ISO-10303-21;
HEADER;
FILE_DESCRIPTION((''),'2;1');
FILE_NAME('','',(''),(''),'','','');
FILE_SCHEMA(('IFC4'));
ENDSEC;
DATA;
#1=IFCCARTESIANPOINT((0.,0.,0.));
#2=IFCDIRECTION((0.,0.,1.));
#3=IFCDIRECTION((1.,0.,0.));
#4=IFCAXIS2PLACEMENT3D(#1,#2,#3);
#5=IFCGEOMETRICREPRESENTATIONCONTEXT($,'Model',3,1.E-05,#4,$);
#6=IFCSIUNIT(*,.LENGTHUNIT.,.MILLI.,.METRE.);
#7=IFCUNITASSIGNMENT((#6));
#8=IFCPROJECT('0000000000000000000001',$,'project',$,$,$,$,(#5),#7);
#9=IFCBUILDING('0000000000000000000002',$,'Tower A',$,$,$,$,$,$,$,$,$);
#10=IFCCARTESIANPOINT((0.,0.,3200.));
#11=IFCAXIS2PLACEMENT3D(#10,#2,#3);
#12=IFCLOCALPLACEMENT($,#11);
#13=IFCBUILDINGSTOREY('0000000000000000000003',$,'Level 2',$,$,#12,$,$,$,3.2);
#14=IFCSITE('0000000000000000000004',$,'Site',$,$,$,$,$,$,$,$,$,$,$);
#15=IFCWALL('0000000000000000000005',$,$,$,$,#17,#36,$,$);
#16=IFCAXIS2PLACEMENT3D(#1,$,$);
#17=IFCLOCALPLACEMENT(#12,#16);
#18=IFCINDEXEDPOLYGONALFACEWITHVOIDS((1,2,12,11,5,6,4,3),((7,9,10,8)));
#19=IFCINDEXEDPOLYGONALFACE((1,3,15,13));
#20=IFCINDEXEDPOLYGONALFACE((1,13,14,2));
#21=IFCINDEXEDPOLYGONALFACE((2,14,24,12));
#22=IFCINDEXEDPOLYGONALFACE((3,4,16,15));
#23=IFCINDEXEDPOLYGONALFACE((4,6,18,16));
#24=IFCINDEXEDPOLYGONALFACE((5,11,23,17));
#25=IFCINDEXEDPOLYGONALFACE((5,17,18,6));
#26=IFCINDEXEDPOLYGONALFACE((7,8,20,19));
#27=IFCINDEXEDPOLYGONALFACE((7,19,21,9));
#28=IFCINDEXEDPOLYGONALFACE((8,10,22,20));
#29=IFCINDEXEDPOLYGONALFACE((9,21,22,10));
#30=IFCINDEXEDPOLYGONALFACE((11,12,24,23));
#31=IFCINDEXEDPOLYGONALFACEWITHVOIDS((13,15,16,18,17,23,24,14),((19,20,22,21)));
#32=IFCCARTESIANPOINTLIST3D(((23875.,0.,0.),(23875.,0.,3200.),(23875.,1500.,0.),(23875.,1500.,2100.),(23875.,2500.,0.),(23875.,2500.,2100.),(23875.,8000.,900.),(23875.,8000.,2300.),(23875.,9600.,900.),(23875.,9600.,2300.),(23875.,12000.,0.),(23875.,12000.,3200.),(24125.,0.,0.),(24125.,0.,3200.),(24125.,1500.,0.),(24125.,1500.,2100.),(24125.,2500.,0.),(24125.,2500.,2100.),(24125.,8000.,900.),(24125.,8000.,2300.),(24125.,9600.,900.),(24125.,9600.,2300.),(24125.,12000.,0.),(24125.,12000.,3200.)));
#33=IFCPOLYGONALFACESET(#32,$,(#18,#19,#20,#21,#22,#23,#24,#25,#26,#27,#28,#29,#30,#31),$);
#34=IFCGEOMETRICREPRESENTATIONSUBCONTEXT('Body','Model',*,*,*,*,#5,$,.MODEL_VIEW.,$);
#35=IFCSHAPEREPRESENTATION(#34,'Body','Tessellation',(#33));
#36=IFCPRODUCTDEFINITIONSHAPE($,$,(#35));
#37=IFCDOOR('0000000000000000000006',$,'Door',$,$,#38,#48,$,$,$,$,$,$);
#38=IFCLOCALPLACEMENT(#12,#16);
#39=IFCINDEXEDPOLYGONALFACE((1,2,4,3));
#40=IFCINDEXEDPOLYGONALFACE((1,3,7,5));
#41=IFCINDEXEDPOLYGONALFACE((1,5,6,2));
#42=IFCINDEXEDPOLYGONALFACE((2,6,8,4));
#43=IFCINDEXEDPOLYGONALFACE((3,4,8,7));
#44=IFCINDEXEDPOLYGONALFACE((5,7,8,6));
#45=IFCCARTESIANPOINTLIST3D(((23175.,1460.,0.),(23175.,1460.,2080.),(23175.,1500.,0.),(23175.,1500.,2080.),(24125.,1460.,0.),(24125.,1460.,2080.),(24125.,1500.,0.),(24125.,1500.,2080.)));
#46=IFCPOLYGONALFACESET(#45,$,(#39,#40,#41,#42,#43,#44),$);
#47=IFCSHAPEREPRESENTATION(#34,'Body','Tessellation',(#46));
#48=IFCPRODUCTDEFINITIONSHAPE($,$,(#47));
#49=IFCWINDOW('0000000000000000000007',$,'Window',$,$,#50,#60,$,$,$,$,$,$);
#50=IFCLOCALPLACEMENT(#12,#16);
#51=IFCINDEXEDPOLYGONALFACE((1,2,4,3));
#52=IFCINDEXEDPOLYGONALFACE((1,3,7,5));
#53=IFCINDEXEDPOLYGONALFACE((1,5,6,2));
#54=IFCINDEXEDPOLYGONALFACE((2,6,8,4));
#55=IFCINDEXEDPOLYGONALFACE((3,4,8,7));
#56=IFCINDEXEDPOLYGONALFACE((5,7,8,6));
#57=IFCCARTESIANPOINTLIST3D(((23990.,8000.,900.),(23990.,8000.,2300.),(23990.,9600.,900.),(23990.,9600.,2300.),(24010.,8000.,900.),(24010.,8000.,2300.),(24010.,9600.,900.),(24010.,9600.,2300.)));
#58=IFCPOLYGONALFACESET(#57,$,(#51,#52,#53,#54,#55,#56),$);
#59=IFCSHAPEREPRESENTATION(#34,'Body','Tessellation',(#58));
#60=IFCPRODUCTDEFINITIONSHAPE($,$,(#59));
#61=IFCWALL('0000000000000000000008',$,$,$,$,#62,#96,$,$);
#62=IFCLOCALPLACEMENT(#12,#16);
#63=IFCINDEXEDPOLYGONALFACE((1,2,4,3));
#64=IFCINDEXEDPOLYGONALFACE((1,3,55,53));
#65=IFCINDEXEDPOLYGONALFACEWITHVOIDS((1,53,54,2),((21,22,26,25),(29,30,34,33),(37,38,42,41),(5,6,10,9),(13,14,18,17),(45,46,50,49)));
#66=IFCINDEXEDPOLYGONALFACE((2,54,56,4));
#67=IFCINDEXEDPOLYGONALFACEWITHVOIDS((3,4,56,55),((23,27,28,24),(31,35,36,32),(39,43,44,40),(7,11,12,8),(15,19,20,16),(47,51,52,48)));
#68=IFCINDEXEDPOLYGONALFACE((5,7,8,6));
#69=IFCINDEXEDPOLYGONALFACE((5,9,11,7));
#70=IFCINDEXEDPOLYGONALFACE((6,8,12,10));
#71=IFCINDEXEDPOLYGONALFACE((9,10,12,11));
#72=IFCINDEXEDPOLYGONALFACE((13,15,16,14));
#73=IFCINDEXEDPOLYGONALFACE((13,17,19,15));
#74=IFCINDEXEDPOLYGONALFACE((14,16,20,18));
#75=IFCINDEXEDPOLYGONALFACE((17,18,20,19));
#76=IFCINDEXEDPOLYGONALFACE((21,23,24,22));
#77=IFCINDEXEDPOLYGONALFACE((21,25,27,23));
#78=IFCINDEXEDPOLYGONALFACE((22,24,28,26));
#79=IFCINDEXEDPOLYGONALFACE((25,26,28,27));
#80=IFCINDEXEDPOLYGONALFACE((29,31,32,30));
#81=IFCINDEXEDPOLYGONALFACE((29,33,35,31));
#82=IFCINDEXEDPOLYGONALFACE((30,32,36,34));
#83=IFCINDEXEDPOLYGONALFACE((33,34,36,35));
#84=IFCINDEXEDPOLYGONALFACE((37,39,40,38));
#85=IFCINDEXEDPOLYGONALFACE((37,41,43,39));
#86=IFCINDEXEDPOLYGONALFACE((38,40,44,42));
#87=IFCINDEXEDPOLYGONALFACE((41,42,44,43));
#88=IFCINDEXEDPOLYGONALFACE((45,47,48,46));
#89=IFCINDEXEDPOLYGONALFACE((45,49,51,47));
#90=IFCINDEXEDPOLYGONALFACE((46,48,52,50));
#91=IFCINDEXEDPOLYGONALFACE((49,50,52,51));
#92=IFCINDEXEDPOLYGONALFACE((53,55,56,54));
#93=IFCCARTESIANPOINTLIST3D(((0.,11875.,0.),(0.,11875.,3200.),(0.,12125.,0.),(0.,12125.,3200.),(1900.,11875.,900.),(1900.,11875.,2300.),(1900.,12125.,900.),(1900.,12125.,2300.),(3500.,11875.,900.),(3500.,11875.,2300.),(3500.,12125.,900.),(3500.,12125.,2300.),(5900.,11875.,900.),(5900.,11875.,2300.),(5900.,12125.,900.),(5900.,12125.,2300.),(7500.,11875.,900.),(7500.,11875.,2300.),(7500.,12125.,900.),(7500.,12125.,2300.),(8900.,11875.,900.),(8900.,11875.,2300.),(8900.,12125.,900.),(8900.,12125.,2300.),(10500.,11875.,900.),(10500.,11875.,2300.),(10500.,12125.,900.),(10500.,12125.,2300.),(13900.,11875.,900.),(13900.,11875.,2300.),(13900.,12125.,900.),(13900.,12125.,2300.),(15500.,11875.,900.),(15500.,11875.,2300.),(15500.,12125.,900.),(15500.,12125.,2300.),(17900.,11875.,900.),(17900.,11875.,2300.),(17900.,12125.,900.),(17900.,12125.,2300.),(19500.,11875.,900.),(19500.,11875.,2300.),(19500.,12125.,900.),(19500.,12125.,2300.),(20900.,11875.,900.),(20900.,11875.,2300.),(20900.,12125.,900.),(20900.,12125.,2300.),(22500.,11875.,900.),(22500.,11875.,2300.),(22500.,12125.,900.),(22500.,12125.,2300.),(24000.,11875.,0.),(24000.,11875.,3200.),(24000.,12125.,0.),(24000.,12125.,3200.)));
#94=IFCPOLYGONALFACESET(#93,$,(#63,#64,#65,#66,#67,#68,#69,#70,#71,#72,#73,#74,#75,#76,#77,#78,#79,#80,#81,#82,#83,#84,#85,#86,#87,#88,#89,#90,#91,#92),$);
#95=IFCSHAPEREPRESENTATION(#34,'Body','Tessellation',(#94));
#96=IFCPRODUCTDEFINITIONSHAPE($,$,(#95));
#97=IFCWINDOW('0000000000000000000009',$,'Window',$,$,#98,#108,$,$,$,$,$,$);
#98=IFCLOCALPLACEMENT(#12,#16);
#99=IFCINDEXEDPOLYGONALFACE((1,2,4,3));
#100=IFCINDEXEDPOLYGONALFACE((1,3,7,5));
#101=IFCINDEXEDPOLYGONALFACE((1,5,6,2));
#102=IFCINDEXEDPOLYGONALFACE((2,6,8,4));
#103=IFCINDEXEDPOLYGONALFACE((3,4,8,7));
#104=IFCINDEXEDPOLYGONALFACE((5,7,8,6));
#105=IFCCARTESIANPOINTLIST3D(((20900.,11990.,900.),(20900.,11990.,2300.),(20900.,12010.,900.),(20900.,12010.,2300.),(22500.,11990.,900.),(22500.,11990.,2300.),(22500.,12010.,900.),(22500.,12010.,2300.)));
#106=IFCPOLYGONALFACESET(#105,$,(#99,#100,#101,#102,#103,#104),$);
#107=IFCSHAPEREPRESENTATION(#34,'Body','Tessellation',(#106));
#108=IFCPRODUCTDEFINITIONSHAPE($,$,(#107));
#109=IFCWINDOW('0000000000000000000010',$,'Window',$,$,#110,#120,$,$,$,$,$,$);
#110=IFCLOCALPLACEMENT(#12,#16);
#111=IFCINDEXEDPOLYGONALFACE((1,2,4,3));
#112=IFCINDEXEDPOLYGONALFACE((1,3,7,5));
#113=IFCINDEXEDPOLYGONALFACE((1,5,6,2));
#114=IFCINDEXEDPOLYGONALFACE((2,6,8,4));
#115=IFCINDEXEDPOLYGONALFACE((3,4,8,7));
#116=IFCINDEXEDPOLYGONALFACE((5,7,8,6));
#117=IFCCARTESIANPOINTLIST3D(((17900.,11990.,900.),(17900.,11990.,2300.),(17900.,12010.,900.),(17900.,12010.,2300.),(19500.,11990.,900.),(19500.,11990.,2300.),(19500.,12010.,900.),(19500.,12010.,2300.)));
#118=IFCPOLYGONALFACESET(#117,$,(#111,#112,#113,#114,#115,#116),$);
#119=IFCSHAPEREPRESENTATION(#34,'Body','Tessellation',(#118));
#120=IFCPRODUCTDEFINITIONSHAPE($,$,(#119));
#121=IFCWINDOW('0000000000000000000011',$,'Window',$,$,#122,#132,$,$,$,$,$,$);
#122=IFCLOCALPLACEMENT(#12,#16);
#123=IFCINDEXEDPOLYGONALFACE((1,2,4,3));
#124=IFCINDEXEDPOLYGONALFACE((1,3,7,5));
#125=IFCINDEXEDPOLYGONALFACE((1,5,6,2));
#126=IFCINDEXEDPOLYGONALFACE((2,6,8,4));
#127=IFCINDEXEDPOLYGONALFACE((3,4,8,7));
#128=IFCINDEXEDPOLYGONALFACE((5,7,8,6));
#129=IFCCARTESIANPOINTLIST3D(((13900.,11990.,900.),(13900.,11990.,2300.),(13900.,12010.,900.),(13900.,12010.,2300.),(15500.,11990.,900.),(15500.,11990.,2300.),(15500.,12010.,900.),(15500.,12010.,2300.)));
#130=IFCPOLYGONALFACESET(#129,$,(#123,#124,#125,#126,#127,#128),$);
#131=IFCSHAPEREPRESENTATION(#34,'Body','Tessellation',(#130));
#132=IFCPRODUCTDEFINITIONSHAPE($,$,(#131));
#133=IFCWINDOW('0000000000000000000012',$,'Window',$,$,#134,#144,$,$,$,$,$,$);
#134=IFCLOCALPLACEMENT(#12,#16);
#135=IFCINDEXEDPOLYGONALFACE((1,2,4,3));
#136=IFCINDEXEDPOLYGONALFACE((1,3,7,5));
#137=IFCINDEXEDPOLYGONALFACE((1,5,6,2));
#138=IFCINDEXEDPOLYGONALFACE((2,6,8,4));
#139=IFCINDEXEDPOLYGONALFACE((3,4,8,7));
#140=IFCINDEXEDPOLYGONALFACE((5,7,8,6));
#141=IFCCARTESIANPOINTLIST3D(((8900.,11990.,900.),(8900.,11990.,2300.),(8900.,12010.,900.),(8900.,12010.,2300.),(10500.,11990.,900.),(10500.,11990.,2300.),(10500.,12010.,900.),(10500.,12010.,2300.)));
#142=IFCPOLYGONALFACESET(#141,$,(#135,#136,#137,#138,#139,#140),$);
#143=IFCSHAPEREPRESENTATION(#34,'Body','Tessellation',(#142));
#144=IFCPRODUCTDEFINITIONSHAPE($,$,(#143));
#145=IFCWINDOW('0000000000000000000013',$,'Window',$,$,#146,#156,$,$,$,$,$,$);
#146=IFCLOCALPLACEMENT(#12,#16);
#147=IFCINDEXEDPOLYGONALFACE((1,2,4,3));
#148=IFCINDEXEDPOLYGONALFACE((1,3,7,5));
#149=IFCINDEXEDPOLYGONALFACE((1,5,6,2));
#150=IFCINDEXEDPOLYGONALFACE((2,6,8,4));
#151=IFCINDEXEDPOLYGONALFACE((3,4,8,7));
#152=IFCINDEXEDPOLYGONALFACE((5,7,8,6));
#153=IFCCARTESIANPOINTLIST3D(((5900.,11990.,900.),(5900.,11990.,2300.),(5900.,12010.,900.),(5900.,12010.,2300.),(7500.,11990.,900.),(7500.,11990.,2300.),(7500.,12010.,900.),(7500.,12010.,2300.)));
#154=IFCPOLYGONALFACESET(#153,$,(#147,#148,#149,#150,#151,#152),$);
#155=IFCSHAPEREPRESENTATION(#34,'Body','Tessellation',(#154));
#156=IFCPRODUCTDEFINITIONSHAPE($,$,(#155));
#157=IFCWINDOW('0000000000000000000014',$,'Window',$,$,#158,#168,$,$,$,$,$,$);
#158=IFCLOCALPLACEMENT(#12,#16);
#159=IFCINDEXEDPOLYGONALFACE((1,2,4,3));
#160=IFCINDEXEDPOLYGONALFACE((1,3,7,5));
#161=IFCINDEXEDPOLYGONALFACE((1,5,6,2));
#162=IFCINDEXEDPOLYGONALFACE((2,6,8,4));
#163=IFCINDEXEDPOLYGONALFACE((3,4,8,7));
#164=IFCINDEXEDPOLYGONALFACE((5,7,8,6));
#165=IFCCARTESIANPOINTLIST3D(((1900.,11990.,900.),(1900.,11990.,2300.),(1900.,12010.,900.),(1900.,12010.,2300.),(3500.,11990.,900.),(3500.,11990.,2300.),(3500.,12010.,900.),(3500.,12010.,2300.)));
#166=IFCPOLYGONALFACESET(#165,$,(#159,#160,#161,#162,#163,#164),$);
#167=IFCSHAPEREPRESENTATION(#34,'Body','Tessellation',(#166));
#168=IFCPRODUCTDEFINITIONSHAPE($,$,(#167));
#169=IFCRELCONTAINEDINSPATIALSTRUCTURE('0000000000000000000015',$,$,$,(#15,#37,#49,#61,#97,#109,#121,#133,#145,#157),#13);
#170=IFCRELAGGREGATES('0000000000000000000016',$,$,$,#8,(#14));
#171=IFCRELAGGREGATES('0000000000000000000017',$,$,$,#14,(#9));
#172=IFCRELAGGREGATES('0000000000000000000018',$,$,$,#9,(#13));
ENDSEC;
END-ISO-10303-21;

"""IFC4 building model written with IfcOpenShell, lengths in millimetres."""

from ifc_helpers import new_model, si_unit, frame, origin_with_axes, place, context, subcontext, project, spatial, indexed_curve, outline, extrude, element, fill, save


model = new_model("IFC4")

# Units and contexts
model_context = context("Model", 3, precision=1e-05, world=origin_with_axes())
body_context = subcontext(model_context, "Body", "Model", "MODEL_VIEW")
ifc_project = project(units=[si_unit("LENGTHUNIT", "METRE", prefix="MILLI")], contexts=[model_context])

# Site, building, storey
site = spatial("IfcSite", under=ifc_project, Name="Site")
building = spatial("IfcBuilding", under=site, Name="Tower A")
storey_placement = place(None, frame((0.0, 0.0, 3200.0), z_axis=(0.0, 0.0, 1.0), x_axis=(1.0, 0.0, 0.0)))
storey = spatial("IfcBuildingStorey", under=building, at=storey_placement, Name="Level 2", Elevation=3.2)

# Wall, openings, door, window
wall_1_placement = place(storey_placement, frame((24125.0, 0.0, 0.0), z_axis=(0.0, 0.0, 1.0), x_axis=(0.0, 1.0, 0.0)))
wall_1 = element("IfcWall", 1, at=wall_1_placement, inside=storey, context=body_context, shape_type="SweptSolid", body=[
    extrude(outline(indexed_curve([(0.0, 0.0), (0.0, 250.0), (12000.0, 250.0), (12000.0, 0.0), (0.0, 0.0)], self_intersect=False)), origin_with_axes(), (0.0, 0.0, 1.0), 3200.0),
])
opening_1_placement = place(wall_1_placement, frame((1500.0, 0.0, 0.0), z_axis=(0.0, 0.0, 1.0), x_axis=(1.0, 0.0, 0.0)))
opening_1 = element("IfcOpeningElement", 2, at=opening_1_placement, cuts=wall_1, context=body_context, shape_type="SweptSolid", body=[
    extrude(outline(indexed_curve([(0.0, 0.0), (0.0, 250.0), (1000.0, 250.0), (1000.0, 0.0), (0.0, 0.0)], self_intersect=False)), origin_with_axes(), (0.0, 0.0, 1.0), 2100.0),
])
opening_2_placement = place(wall_1_placement, frame((8000.0, 0.0, 900.0), z_axis=(0.0, 0.0, 1.0), x_axis=(1.0, 0.0, 0.0)))
opening_2 = element("IfcOpeningElement", 3, at=opening_2_placement, cuts=wall_1, context=body_context, shape_type="SweptSolid", body=[
    extrude(outline(indexed_curve([(0.0, 0.0), (0.0, 250.0), (1600.0, 250.0), (1600.0, 0.0), (0.0, 0.0)], self_intersect=False)), origin_with_axes(), (0.0, 0.0, 1.0), 1400.0),
])
door_1_placement = place(storey_placement, frame((24125.0, 1500.0, 0.0), z_axis=(0.0, 0.0, 1.0), x_axis=(-1.0, 0.0, 0.0)))
door_1 = element("IfcDoor", 4, at=door_1_placement, inside=storey, Name="Door", context=body_context, shape_type="SweptSolid", body=[
    extrude(outline(indexed_curve([(0.0, 0.0), (0.0, 40.0), (950.0, 40.0), (950.0, 0.0), (0.0, 0.0)], self_intersect=False)), origin_with_axes(), (0.0, 0.0, 1.0), 2080.0),
])
fill(opening_1, door_1)
window_1_placement = place(storey_placement, frame((24010.0, 8000.0, 900.0), z_axis=(0.0, 0.0, 1.0), x_axis=(0.0, 1.0, 0.0)))
window_1 = element("IfcWindow", 5, at=window_1_placement, inside=storey, Name="Window", context=body_context, shape_type="SweptSolid", body=[
    extrude(outline(indexed_curve([(0.0, 0.0), (0.0, 20.0), (1600.0, 20.0), (1600.0, 0.0), (0.0, 0.0)], self_intersect=False)), origin_with_axes(), (0.0, 0.0, 1.0), 1400.0),
])
fill(opening_2, window_1)

# Wall, openings, windows
wall_2_placement = place(storey_placement, frame((24000.0, 12125.0, 0.0), z_axis=(0.0, 0.0, 1.0), x_axis=(-1.0, 0.0, 0.0)))
wall_2 = element("IfcWall", 6, at=wall_2_placement, inside=storey, context=body_context, shape_type="SweptSolid", body=[
    extrude(outline(indexed_curve([(0.0, 0.0), (0.0, 250.0), (24000.0, 250.0), (24000.0, 0.0), (0.0, 0.0)], self_intersect=False)), origin_with_axes(), (0.0, 0.0, 1.0), 3200.0),
])
opening_3_placement = place(wall_2_placement, frame((1500.0, 0.0, 900.0), z_axis=(0.0, 0.0, 1.0), x_axis=(1.0, 0.0, 0.0)))
opening_3 = element("IfcOpeningElement", 7, at=opening_3_placement, cuts=wall_2, context=body_context, shape_type="SweptSolid", body=[
    extrude(outline(indexed_curve([(0.0, 0.0), (0.0, 250.0), (1600.0, 250.0), (1600.0, 0.0), (0.0, 0.0)], self_intersect=False)), origin_with_axes(), (0.0, 0.0, 1.0), 1400.0),
])
opening_4_placement = place(wall_2_placement, frame((4500.0, 0.0, 900.0), z_axis=(0.0, 0.0, 1.0), x_axis=(1.0, 0.0, 0.0)))
opening_4 = element("IfcOpeningElement", 8, at=opening_4_placement, cuts=wall_2, context=body_context, shape_type="SweptSolid", body=[
    extrude(outline(indexed_curve([(0.0, 0.0), (0.0, 250.0), (1600.0, 250.0), (1600.0, 0.0), (0.0, 0.0)], self_intersect=False)), origin_with_axes(), (0.0, 0.0, 1.0), 1400.0),
])
opening_5_placement = place(wall_2_placement, frame((8500.0, 0.0, 900.0), z_axis=(0.0, 0.0, 1.0), x_axis=(1.0, 0.0, 0.0)))
opening_5 = element("IfcOpeningElement", 9, at=opening_5_placement, cuts=wall_2, context=body_context, shape_type="SweptSolid", body=[
    extrude(outline(indexed_curve([(0.0, 0.0), (0.0, 250.0), (1600.0, 250.0), (1600.0, 0.0), (0.0, 0.0)], self_intersect=False)), origin_with_axes(), (0.0, 0.0, 1.0), 1400.0),
])
opening_6_placement = place(wall_2_placement, frame((13500.0, 0.0, 900.0), z_axis=(0.0, 0.0, 1.0), x_axis=(1.0, 0.0, 0.0)))
opening_6 = element("IfcOpeningElement", 10, at=opening_6_placement, cuts=wall_2, context=body_context, shape_type="SweptSolid", body=[
    extrude(outline(indexed_curve([(0.0, 0.0), (0.0, 250.0), (1600.0, 250.0), (1600.0, 0.0), (0.0, 0.0)], self_intersect=False)), origin_with_axes(), (0.0, 0.0, 1.0), 1400.0),
])
opening_7_placement = place(wall_2_placement, frame((16500.0, 0.0, 900.0), z_axis=(0.0, 0.0, 1.0), x_axis=(1.0, 0.0, 0.0)))
opening_7 = element("IfcOpeningElement", 11, at=opening_7_placement, cuts=wall_2, context=body_context, shape_type="SweptSolid", body=[
    extrude(outline(indexed_curve([(0.0, 0.0), (0.0, 250.0), (1600.0, 250.0), (1600.0, 0.0), (0.0, 0.0)], self_intersect=False)), origin_with_axes(), (0.0, 0.0, 1.0), 1400.0),
])
opening_8_placement = place(wall_2_placement, frame((20500.0, 0.0, 900.0), z_axis=(0.0, 0.0, 1.0), x_axis=(1.0, 0.0, 0.0)))
opening_8 = element("IfcOpeningElement", 12, at=opening_8_placement, cuts=wall_2, context=body_context, shape_type="SweptSolid", body=[
    extrude(outline(indexed_curve([(0.0, 0.0), (0.0, 250.0), (1600.0, 250.0), (1600.0, 0.0), (0.0, 0.0)], self_intersect=False)), origin_with_axes(), (0.0, 0.0, 1.0), 1400.0),
])
window_2_placement = place(storey_placement, frame((22500.0, 12010.0, 900.0), z_axis=(0.0, 0.0, 1.0), x_axis=(-1.0, 0.0, 0.0)))
window_2 = element("IfcWindow", 13, at=window_2_placement, inside=storey, Name="Window", context=body_context, shape_type="SweptSolid", body=[
    extrude(outline(indexed_curve([(0.0, 0.0), (0.0, 20.0), (1600.0, 20.0), (1600.0, 0.0), (0.0, 0.0)], self_intersect=False)), origin_with_axes(), (0.0, 0.0, 1.0), 1400.0),
])
fill(opening_3, window_2)
window_3_placement = place(storey_placement, frame((19500.0, 12010.0, 900.0), z_axis=(0.0, 0.0, 1.0), x_axis=(-1.0, 0.0, 0.0)))
window_3 = element("IfcWindow", 14, at=window_3_placement, inside=storey, Name="Window", context=body_context, shape_type="SweptSolid", body=[
    extrude(outline(indexed_curve([(0.0, 0.0), (0.0, 20.0), (1600.0, 20.0), (1600.0, 0.0), (0.0, 0.0)], self_intersect=False)), origin_with_axes(), (0.0, 0.0, 1.0), 1400.0),
])
fill(opening_4, window_3)
window_4_placement = place(storey_placement, frame((15500.0, 12010.0, 900.0), z_axis=(0.0, 0.0, 1.0), x_axis=(-1.0, 0.0, 0.0)))
window_4 = element("IfcWindow", 15, at=window_4_placement, inside=storey, Name="Window", context=body_context, shape_type="SweptSolid", body=[
    extrude(outline(indexed_curve([(0.0, 0.0), (0.0, 20.0), (1600.0, 20.0), (1600.0, 0.0), (0.0, 0.0)], self_intersect=False)), origin_with_axes(), (0.0, 0.0, 1.0), 1400.0),
])
fill(opening_5, window_4)
window_5_placement = place(storey_placement, frame((10500.0, 12010.0, 900.0), z_axis=(0.0, 0.0, 1.0), x_axis=(-1.0, 0.0, 0.0)))
window_5 = element("IfcWindow", 16, at=window_5_placement, inside=storey, Name="Window", context=body_context, shape_type="SweptSolid", body=[
    extrude(outline(indexed_curve([(0.0, 0.0), (0.0, 20.0), (1600.0, 20.0), (1600.0, 0.0), (0.0, 0.0)], self_intersect=False)), origin_with_axes(), (0.0, 0.0, 1.0), 1400.0),
])
fill(opening_6, window_5)
window_6_placement = place(storey_placement, frame((7500.0, 12010.0, 900.0), z_axis=(0.0, 0.0, 1.0), x_axis=(-1.0, 0.0, 0.0)))
window_6 = element("IfcWindow", 17, at=window_6_placement, inside=storey, Name="Window", context=body_context, shape_type="SweptSolid", body=[
    extrude(outline(indexed_curve([(0.0, 0.0), (0.0, 20.0), (1600.0, 20.0), (1600.0, 0.0), (0.0, 0.0)], self_intersect=False)), origin_with_axes(), (0.0, 0.0, 1.0), 1400.0),
])
fill(opening_7, window_6)
window_7_placement = place(storey_placement, frame((3500.0, 12010.0, 900.0), z_axis=(0.0, 0.0, 1.0), x_axis=(-1.0, 0.0, 0.0)))
window_7 = element("IfcWindow", 18, at=window_7_placement, inside=storey, Name="Window", context=body_context, shape_type="SweptSolid", body=[
    extrude(outline(indexed_curve([(0.0, 0.0), (0.0, 20.0), (1600.0, 20.0), (1600.0, 0.0), (0.0, 0.0)], self_intersect=False)), origin_with_axes(), (0.0, 0.0, 1.0), 1400.0),
])
fill(opening_8, window_7)

save(model, "model.ifc")
